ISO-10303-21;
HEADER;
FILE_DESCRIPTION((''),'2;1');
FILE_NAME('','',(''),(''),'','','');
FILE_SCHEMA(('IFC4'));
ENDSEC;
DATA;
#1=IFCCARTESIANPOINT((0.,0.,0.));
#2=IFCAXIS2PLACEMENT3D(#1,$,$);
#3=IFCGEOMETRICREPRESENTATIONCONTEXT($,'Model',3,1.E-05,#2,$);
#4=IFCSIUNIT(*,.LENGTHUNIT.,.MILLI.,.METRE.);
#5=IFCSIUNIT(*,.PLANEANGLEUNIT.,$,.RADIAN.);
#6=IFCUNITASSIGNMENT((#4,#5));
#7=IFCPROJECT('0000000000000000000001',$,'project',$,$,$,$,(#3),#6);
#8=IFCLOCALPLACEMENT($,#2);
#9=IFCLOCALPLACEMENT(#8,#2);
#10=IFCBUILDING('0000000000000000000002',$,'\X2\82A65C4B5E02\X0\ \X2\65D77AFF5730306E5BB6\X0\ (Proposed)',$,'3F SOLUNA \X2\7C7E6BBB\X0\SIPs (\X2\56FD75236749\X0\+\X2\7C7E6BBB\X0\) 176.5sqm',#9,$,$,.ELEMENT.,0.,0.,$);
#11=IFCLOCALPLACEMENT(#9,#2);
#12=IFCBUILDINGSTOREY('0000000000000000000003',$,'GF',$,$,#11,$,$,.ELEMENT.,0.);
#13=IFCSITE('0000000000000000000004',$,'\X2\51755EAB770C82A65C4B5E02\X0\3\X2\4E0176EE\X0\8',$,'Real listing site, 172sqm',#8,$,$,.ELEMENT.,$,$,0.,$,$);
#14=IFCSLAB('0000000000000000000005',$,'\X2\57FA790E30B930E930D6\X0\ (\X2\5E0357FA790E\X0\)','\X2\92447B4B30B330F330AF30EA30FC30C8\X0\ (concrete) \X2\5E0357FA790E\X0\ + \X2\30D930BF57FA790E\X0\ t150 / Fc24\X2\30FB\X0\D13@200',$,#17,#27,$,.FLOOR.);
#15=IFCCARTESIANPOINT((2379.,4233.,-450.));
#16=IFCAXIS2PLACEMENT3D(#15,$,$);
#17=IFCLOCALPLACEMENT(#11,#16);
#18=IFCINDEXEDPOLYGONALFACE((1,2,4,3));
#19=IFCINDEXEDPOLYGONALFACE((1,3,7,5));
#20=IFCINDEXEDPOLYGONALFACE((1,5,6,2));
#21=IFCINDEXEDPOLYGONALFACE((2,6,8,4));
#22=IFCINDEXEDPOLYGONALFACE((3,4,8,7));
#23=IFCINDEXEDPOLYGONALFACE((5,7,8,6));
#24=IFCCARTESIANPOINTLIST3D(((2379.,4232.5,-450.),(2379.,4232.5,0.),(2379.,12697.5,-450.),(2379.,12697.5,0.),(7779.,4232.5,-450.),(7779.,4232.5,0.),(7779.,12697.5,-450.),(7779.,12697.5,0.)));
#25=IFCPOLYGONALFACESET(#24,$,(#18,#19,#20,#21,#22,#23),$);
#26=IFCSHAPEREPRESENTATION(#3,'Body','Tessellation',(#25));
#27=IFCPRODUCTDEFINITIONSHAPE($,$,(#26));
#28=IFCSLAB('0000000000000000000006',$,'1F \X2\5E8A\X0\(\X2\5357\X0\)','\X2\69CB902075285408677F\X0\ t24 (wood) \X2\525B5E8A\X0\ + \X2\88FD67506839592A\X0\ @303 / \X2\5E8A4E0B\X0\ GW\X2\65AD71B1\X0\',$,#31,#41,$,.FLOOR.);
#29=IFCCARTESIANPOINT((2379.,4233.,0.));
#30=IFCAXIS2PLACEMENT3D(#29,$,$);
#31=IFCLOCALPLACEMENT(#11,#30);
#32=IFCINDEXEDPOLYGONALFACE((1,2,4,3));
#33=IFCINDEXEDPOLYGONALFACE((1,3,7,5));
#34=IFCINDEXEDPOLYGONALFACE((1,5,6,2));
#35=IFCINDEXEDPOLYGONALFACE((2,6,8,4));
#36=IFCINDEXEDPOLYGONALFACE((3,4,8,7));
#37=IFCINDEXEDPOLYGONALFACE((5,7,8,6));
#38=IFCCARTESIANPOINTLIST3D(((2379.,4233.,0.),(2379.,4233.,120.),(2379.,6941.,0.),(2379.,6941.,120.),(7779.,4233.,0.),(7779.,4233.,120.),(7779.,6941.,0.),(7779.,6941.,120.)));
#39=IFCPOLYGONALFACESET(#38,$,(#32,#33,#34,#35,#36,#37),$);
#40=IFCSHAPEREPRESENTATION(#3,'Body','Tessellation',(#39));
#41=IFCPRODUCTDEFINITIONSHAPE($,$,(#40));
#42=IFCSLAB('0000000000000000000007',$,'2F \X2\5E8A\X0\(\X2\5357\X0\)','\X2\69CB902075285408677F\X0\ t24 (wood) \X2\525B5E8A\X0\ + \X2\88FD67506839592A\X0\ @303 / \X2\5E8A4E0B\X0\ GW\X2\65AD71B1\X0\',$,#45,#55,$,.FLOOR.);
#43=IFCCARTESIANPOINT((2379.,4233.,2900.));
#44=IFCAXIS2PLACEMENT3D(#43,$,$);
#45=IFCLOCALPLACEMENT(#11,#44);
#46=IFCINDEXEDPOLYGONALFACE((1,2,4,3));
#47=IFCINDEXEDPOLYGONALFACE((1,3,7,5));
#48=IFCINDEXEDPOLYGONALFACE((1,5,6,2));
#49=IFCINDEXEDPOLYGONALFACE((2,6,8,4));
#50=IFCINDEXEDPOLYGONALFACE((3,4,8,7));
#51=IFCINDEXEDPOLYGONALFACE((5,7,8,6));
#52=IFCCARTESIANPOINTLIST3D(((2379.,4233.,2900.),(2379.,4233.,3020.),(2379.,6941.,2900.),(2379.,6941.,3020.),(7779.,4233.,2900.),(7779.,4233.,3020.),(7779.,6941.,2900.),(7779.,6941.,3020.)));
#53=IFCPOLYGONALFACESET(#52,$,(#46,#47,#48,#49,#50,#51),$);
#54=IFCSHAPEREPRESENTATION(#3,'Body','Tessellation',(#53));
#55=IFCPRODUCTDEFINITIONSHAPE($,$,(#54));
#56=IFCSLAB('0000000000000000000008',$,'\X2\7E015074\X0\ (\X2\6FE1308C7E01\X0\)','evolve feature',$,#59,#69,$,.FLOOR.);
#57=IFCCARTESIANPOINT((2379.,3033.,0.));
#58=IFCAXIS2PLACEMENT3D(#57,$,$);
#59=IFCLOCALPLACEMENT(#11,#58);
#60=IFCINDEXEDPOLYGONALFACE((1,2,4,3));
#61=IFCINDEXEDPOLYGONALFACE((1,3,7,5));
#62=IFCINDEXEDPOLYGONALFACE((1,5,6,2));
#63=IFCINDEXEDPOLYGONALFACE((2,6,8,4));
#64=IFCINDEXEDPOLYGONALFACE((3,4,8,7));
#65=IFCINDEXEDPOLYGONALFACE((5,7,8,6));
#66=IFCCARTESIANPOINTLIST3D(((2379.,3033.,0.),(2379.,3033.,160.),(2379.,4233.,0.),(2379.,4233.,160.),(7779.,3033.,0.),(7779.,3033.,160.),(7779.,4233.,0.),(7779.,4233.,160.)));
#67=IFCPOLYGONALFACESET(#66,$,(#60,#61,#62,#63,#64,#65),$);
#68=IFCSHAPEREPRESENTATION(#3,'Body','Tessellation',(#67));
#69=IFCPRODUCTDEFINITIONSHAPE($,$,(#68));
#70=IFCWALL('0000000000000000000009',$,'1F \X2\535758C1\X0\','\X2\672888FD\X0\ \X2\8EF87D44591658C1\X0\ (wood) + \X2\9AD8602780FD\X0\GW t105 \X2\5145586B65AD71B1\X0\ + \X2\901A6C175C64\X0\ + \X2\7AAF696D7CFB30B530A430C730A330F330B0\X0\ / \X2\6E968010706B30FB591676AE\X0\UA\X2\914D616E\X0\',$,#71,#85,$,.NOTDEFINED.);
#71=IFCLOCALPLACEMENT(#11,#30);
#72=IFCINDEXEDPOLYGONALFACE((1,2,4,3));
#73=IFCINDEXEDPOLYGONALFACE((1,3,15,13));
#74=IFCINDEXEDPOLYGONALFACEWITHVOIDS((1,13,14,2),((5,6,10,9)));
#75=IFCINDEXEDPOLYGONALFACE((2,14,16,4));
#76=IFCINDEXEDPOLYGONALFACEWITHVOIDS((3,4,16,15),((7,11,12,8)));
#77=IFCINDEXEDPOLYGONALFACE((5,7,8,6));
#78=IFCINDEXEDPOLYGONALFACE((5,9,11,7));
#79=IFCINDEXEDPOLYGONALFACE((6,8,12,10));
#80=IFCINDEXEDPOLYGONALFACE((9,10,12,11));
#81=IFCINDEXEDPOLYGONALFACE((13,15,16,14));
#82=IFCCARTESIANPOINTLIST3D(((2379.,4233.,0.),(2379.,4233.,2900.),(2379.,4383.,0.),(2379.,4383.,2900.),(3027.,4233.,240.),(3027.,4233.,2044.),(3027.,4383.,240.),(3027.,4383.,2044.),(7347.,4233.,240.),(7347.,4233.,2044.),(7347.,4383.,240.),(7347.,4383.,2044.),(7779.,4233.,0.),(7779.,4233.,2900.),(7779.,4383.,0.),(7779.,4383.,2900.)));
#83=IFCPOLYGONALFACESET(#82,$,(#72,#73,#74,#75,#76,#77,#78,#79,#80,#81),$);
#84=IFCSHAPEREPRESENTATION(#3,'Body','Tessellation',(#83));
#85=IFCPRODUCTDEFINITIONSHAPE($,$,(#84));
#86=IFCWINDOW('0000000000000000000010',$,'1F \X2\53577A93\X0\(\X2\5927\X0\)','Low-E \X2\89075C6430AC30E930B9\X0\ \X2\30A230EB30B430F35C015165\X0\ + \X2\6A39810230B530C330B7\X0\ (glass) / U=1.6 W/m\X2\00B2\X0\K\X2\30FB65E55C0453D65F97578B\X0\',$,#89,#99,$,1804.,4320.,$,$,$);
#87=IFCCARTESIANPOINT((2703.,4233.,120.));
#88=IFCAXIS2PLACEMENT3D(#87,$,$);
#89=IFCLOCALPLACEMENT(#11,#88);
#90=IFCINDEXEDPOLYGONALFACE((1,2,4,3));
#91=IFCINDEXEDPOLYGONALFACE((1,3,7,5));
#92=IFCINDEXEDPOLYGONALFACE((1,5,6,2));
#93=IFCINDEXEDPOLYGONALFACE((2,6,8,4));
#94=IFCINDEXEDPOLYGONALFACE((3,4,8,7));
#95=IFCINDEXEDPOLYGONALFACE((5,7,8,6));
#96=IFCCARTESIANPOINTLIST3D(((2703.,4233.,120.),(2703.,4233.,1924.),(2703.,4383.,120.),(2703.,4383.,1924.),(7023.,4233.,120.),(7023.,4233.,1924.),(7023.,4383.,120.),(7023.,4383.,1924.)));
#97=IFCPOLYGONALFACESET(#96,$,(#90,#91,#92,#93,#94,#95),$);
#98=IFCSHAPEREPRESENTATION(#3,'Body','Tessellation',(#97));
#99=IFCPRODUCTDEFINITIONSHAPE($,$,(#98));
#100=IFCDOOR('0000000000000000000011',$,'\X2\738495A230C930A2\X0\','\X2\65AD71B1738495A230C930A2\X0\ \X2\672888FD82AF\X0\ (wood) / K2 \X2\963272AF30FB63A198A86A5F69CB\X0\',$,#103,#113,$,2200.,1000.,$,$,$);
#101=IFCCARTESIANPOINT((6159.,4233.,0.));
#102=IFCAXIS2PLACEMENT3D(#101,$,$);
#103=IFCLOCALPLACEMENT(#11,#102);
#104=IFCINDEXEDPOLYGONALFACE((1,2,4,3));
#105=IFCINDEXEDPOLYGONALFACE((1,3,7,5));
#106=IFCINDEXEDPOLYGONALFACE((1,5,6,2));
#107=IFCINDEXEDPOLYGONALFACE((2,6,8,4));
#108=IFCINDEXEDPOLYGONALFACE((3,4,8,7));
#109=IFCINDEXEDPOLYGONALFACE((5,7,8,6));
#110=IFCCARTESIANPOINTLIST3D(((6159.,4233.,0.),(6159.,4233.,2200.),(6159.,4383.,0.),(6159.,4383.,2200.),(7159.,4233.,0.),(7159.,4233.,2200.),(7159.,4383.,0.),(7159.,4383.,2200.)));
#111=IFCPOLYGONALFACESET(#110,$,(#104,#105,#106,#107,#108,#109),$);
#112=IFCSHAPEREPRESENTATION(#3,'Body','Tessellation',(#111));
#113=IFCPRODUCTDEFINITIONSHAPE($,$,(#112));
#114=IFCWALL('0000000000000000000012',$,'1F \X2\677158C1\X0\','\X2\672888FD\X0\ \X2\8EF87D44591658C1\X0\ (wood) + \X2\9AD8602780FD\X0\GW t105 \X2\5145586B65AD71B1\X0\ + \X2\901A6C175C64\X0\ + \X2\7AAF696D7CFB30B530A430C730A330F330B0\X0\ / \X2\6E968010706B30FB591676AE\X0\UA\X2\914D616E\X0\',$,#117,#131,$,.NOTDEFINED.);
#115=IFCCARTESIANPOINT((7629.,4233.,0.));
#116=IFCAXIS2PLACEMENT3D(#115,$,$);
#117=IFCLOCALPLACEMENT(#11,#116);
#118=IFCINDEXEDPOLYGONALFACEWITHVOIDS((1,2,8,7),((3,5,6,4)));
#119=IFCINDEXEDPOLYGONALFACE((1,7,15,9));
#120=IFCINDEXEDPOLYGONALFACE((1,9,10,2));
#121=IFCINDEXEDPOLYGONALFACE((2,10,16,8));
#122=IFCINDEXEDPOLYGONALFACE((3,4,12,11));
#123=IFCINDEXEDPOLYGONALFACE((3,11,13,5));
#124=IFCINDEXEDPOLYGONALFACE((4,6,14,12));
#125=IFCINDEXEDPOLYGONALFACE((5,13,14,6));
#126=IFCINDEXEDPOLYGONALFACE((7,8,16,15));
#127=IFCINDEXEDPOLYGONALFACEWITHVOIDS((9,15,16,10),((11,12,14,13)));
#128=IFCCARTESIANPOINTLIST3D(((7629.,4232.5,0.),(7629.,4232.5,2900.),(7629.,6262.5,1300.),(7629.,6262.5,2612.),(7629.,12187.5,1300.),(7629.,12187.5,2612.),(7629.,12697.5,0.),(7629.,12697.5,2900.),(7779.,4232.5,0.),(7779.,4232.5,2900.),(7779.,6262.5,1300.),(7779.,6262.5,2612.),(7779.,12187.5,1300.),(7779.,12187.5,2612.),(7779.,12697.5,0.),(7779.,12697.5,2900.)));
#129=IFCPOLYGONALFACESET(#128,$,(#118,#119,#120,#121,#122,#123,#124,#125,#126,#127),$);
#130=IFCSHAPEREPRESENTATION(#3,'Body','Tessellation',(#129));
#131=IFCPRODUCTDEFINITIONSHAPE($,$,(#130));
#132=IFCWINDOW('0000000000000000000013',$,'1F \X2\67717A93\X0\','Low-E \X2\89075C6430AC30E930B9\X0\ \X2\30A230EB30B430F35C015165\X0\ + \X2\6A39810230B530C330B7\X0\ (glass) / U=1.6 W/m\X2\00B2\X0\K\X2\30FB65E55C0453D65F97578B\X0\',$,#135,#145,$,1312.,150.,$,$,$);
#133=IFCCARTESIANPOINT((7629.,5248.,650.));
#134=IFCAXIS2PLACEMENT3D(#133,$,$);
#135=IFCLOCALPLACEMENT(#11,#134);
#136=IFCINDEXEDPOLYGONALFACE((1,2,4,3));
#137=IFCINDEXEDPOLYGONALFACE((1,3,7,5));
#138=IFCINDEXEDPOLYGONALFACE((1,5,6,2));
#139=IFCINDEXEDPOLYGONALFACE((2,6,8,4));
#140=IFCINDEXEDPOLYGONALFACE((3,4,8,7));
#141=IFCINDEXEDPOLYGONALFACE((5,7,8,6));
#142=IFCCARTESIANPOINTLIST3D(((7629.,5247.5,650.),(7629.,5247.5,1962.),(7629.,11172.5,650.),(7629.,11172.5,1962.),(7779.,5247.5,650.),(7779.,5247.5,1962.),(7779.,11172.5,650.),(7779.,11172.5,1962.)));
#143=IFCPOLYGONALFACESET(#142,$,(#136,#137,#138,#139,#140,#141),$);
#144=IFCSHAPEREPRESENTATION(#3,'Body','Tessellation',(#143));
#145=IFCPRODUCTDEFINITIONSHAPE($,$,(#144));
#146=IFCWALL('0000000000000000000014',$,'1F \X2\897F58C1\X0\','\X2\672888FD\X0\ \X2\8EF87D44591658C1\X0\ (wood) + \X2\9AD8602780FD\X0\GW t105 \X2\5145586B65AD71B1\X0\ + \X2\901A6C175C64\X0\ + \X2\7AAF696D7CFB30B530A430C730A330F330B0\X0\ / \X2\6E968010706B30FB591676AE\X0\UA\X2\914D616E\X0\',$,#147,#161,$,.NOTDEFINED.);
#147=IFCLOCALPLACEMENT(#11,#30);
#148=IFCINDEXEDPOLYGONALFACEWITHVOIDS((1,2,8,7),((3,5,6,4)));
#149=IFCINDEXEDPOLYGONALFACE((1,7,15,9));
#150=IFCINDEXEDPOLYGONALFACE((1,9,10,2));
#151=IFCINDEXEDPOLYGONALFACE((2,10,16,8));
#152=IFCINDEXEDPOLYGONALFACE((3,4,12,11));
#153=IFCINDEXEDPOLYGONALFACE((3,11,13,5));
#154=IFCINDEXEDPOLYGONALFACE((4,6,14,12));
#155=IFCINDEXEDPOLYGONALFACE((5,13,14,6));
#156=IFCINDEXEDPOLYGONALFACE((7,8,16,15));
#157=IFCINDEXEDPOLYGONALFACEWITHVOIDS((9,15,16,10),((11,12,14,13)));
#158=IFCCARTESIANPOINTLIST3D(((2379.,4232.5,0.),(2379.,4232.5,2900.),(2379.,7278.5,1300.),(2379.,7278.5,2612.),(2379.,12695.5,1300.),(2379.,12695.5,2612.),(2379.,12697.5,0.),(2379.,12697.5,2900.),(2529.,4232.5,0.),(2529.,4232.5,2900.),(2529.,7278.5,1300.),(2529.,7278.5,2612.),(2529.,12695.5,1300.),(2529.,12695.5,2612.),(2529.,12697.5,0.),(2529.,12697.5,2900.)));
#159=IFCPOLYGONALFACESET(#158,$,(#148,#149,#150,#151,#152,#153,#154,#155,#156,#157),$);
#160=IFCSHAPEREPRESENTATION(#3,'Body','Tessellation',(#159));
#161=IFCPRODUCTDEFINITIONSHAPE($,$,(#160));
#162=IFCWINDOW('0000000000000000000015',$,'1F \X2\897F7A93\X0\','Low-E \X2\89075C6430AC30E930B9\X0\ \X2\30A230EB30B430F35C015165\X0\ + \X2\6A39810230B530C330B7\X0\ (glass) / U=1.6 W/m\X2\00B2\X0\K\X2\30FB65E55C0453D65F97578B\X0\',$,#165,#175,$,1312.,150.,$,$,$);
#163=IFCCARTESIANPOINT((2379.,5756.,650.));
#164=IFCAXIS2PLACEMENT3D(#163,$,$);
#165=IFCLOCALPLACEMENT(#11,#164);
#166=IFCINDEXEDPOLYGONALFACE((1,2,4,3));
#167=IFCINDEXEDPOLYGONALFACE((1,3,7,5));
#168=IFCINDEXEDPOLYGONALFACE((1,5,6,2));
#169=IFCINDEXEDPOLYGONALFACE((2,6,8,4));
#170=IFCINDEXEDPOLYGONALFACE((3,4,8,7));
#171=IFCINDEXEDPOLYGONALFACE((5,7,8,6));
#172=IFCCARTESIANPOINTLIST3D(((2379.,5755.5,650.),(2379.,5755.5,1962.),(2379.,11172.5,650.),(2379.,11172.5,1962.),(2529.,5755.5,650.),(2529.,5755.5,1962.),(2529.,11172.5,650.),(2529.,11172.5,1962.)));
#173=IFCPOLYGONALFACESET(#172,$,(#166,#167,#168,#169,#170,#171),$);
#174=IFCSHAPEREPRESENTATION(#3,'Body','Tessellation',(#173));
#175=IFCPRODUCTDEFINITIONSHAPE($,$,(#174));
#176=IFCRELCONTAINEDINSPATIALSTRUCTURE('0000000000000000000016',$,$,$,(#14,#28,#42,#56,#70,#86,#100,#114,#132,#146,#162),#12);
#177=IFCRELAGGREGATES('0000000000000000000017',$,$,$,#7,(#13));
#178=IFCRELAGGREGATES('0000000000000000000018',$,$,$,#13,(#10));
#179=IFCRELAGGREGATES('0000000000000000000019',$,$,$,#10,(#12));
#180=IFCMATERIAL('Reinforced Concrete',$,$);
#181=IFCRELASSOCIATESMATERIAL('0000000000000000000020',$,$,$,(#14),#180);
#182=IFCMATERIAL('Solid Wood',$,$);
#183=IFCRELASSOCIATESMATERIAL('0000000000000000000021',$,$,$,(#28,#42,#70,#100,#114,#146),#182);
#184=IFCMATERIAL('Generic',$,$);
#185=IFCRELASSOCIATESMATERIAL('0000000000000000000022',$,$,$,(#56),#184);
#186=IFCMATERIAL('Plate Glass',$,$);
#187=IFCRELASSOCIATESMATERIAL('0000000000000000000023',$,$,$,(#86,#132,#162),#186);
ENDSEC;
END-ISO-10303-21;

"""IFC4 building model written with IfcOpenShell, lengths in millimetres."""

from ifc_helpers import new_model, si_unit, frame, frame_2d, origin, place, context, project, spatial, rectangle, extrude, material, element, fill, save


model = new_model("IFC4")

# Units and contexts
model_context = context("Model", 3, precision=1e-05, world=origin())
ifc_project = project(units=[si_unit("LENGTHUNIT", "METRE", prefix="MILLI"), si_unit("PLANEANGLEUNIT", "RADIAN")], contexts=[model_context])

# Site, building, storey
site_placement = place(None, origin())
site = spatial("IfcSite", under=ifc_project, at=site_placement, Name="兵庫県芦屋市3丁目8", ObjectType="Real listing site, 172sqm", CompositionType="ELEMENT", RefElevation=0.0)
building_placement = place(site_placement, origin())
building = spatial("IfcBuilding", under=site, at=building_placement, Name="芦屋市 旗竿地の家 (Proposed)", ObjectType="3F SOLUNA 籾殻SIPs (国産杉+籾殻) 176.5sqm", CompositionType="ELEMENT", ElevationOfRefHeight=0.0, ElevationOfTerrain=0.0)
storey_placement = place(building_placement, origin())
storey = spatial("IfcBuildingStorey", under=building, at=storey_placement, Name="GF", CompositionType="ELEMENT", Elevation=0.0)

# Slabs
ifc_material_1 = material(Name="Reinforced Concrete")
slab_1_placement = place(storey_placement, frame((2379.0, 4233.0, -450.0)))
element("IfcSlab", 1, at=slab_1_placement, inside=storey, material=ifc_material_1, Name="基礎スラブ (布基礎)", Description="鉄筋コンクリート (concrete) 布基礎 + ベタ基礎 t150 / Fc24・D13@200", PredefinedType="FLOOR", context=model_context, shape_type="SweptSolid", body=[
    extrude(rectangle(XDim=5400.0, YDim=8465.0, at=frame_2d((2700.0, 4232.0))), frame((2379.0, 4233.0, -450.0)), (0.0, 0.0, 1.0), 450.0),
])
ifc_material_2 = material(Name="Solid Wood")
slab_2_placement = place(storey_placement, frame((2379.0, 4233.0, 0.0)))
element("IfcSlab", 2, at=slab_2_placement, inside=storey, material=ifc_material_2, Name="1F 床(南)", Description="構造用合板 t24 (wood) 剛床 + 製材根太 @303 / 床下 GW断熱", PredefinedType="FLOOR", context=model_context, shape_type="SweptSolid", body=[
    extrude(rectangle(XDim=5400.0, YDim=2708.0, at=frame_2d((2700.0, 1354.0))), frame((2379.0, 4233.0, 0.0)), (0.0, 0.0, 1.0), 120.0),
])
slab_3_placement = place(storey_placement, frame((2379.0, 4233.0, 2900.0)))
element("IfcSlab", 3, at=slab_3_placement, inside=storey, material=ifc_material_2, Name="2F 床(南)", Description="構造用合板 t24 (wood) 剛床 + 製材根太 @303 / 床下 GW断熱", PredefinedType="FLOOR", context=model_context, shape_type="SweptSolid", body=[
    extrude(rectangle(XDim=5400.0, YDim=2708.0, at=frame_2d((2700.0, 1354.0))), frame((2379.0, 4233.0, 2900.0)), (0.0, 0.0, 1.0), 120.0),
])
ifc_material_3 = material(Name="Generic")
slab_4_placement = place(storey_placement, frame((2379.0, 3033.0, 0.0)))
element("IfcSlab", 4, at=slab_4_placement, inside=storey, material=ifc_material_3, Name="縁側 (濡れ縁)", Description="evolve feature", PredefinedType="FLOOR", context=model_context, shape_type="SweptSolid", body=[
    extrude(rectangle(XDim=5400.0, YDim=1200.0, at=frame_2d((2700.0, 600.0))), frame((2379.0, 3033.0, 0.0)), (0.0, 0.0, 1.0), 160.0),
])

# Wall, openings, window, door
wall_1_placement = place(storey_placement, frame((2379.0, 4233.0, 0.0)))
wall_1 = element("IfcWall", 5, at=wall_1_placement, inside=storey, material=ifc_material_2, Name="1F 南壁", Description="木製 軸組外壁 (wood) + 高性能GW t105 充填断熱 + 通気層 + 窯業系サイディング / 準耐火・外皮UA配慮", PredefinedType="NOTDEFINED", context=model_context, shape_type="SweptSolid", body=[
    extrude(rectangle(XDim=5400.0, YDim=150.0, at=frame_2d((2700.0, 75.0))), frame((2379.0, 4233.0, 0.0)), (0.0, 0.0, 1.0), 2900.0),
])
opening_1_placement = place(storey_placement, frame((2703.0, 4233.0, 120.0)))
opening_1 = element("IfcOpeningElement", 6, at=opening_1_placement, cuts=wall_1, PredefinedType="NOTDEFINED", context=model_context, shape_type="SweptSolid", body=[
    extrude(rectangle(XDim=4320.0, YDim=150.0, at=frame_2d((2160.0, 75.0))), frame((2703.0, 4233.0, 120.0)), (0.0, 0.0, 1.0), 1804.0),
])
opening_2_placement = place(storey_placement, frame((6159.0, 4233.0, 0.0)))
opening_2 = element("IfcOpeningElement", 7, at=opening_2_placement, cuts=wall_1, PredefinedType="NOTDEFINED", context=model_context, shape_type="SweptSolid", body=[
    extrude(rectangle(XDim=1000.0, YDim=150.0, at=frame_2d((500.0, 75.0))), frame((6159.0, 4233.0, 0.0)), (0.0, 0.0, 1.0), 2200.0),
])
ifc_material_4 = material(Name="Plate Glass")
window_1_placement = place(storey_placement, frame((2703.0, 4233.0, 120.0)))
window_1 = element("IfcWindow", 8, at=window_1_placement, inside=storey, material=ifc_material_4, Name="1F 南窓(大)", Description="Low-E 複層ガラス アルゴン封入 + 樹脂サッシ (glass) / U=1.6 W/m²K・日射取得型", OverallHeight=1804.0, OverallWidth=4320.0, context=model_context, shape_type="SweptSolid", body=[
    extrude(rectangle(XDim=4320.0, YDim=150.0, at=frame_2d((2160.0, 75.0))), frame((2703.0, 4233.0, 120.0)), (0.0, 0.0, 1.0), 1804.0),
])
fill(opening_1, window_1)
door_placement = place(storey_placement, frame((6159.0, 4233.0, 0.0)))
door = element("IfcDoor", 9, at=door_placement, inside=storey, material=ifc_material_2, Name="玄関ドア", Description="断熱玄関ドア 木製芯 (wood) / K2 防犯・採風機構", OverallHeight=2200.0, OverallWidth=1000.0, context=model_context, shape_type="SweptSolid", body=[
    extrude(rectangle(XDim=1000.0, YDim=150.0, at=frame_2d((500.0, 75.0))), frame((6159.0, 4233.0, 0.0)), (0.0, 0.0, 1.0), 2200.0),
])
fill(opening_2, door)

# Walls, openings, windows
wall_2_placement = place(storey_placement, frame((7629.0, 4233.0, 0.0)))
wall_2 = element("IfcWall", 10, at=wall_2_placement, inside=storey, material=ifc_material_2, Name="1F 東壁", Description="木製 軸組外壁 (wood) + 高性能GW t105 充填断熱 + 通気層 + 窯業系サイディング / 準耐火・外皮UA配慮", PredefinedType="NOTDEFINED", context=model_context, shape_type="SweptSolid", body=[
    extrude(rectangle(XDim=150.0, YDim=8465.0, at=frame_2d((75.0, 4232.0))), frame((7629.0, 4233.0, 0.0)), (0.0, 0.0, 1.0), 2900.0),
])
opening_3_placement = place(storey_placement, frame((7629.0, 5248.0, 650.0)))
opening_3 = element("IfcOpeningElement", 11, at=opening_3_placement, cuts=wall_2, PredefinedType="NOTDEFINED", context=model_context, shape_type="SweptSolid", body=[
    extrude(rectangle(XDim=150.0, YDim=5925.0, at=frame_2d((75.0, 2962.0))), frame((7629.0, 5248.0, 650.0)), (0.0, 0.0, 1.0), 1312.0),
])
window_2_placement = place(storey_placement, frame((7629.0, 5248.0, 650.0)))
window_2 = element("IfcWindow", 12, at=window_2_placement, inside=storey, material=ifc_material_4, Name="1F 東窓", Description="Low-E 複層ガラス アルゴン封入 + 樹脂サッシ (glass) / U=1.6 W/m²K・日射取得型", OverallHeight=1312.0, OverallWidth=150.0, context=model_context, shape_type="SweptSolid", body=[
    extrude(rectangle(XDim=150.0, YDim=5925.0, at=frame_2d((75.0, 2962.0))), frame((7629.0, 5248.0, 650.0)), (0.0, 0.0, 1.0), 1312.0),
])
fill(opening_3, window_2)
wall_3_placement = place(storey_placement, frame((2379.0, 4233.0, 0.0)))
wall_3 = element("IfcWall", 13, at=wall_3_placement, inside=storey, material=ifc_material_2, Name="1F 西壁", Description="木製 軸組外壁 (wood) + 高性能GW t105 充填断熱 + 通気層 + 窯業系サイディング / 準耐火・外皮UA配慮", PredefinedType="NOTDEFINED", context=model_context, shape_type="SweptSolid", body=[
    extrude(rectangle(XDim=150.0, YDim=8465.0, at=frame_2d((75.0, 4232.0))), frame((2379.0, 4233.0, 0.0)), (0.0, 0.0, 1.0), 2900.0),
])
opening_4_placement = place(storey_placement, frame((2379.0, 5756.0, 650.0)))
opening_4 = element("IfcOpeningElement", 14, at=opening_4_placement, cuts=wall_3, PredefinedType="NOTDEFINED", context=model_context, shape_type="SweptSolid", body=[
    extrude(rectangle(XDim=150.0, YDim=5417.0, at=frame_2d((75.0, 2708.0))), frame((2379.0, 5756.0, 650.0)), (0.0, 0.0, 1.0), 1312.0),
])
window_3_placement = place(storey_placement, frame((2379.0, 5756.0, 650.0)))
window_3 = element("IfcWindow", 15, at=window_3_placement, inside=storey, material=ifc_material_4, Name="1F 西窓", Description="Low-E 複層ガラス アルゴン封入 + 樹脂サッシ (glass) / U=1.6 W/m²K・日射取得型", OverallHeight=1312.0, OverallWidth=150.0, context=model_context, shape_type="SweptSolid", body=[
    extrude(rectangle(XDim=150.0, YDim=5417.0, at=frame_2d((75.0, 2708.0))), frame((2379.0, 5756.0, 650.0)), (0.0, 0.0, 1.0), 1312.0),
])
fill(opening_4, window_3)

save(model, "model.ifc")
